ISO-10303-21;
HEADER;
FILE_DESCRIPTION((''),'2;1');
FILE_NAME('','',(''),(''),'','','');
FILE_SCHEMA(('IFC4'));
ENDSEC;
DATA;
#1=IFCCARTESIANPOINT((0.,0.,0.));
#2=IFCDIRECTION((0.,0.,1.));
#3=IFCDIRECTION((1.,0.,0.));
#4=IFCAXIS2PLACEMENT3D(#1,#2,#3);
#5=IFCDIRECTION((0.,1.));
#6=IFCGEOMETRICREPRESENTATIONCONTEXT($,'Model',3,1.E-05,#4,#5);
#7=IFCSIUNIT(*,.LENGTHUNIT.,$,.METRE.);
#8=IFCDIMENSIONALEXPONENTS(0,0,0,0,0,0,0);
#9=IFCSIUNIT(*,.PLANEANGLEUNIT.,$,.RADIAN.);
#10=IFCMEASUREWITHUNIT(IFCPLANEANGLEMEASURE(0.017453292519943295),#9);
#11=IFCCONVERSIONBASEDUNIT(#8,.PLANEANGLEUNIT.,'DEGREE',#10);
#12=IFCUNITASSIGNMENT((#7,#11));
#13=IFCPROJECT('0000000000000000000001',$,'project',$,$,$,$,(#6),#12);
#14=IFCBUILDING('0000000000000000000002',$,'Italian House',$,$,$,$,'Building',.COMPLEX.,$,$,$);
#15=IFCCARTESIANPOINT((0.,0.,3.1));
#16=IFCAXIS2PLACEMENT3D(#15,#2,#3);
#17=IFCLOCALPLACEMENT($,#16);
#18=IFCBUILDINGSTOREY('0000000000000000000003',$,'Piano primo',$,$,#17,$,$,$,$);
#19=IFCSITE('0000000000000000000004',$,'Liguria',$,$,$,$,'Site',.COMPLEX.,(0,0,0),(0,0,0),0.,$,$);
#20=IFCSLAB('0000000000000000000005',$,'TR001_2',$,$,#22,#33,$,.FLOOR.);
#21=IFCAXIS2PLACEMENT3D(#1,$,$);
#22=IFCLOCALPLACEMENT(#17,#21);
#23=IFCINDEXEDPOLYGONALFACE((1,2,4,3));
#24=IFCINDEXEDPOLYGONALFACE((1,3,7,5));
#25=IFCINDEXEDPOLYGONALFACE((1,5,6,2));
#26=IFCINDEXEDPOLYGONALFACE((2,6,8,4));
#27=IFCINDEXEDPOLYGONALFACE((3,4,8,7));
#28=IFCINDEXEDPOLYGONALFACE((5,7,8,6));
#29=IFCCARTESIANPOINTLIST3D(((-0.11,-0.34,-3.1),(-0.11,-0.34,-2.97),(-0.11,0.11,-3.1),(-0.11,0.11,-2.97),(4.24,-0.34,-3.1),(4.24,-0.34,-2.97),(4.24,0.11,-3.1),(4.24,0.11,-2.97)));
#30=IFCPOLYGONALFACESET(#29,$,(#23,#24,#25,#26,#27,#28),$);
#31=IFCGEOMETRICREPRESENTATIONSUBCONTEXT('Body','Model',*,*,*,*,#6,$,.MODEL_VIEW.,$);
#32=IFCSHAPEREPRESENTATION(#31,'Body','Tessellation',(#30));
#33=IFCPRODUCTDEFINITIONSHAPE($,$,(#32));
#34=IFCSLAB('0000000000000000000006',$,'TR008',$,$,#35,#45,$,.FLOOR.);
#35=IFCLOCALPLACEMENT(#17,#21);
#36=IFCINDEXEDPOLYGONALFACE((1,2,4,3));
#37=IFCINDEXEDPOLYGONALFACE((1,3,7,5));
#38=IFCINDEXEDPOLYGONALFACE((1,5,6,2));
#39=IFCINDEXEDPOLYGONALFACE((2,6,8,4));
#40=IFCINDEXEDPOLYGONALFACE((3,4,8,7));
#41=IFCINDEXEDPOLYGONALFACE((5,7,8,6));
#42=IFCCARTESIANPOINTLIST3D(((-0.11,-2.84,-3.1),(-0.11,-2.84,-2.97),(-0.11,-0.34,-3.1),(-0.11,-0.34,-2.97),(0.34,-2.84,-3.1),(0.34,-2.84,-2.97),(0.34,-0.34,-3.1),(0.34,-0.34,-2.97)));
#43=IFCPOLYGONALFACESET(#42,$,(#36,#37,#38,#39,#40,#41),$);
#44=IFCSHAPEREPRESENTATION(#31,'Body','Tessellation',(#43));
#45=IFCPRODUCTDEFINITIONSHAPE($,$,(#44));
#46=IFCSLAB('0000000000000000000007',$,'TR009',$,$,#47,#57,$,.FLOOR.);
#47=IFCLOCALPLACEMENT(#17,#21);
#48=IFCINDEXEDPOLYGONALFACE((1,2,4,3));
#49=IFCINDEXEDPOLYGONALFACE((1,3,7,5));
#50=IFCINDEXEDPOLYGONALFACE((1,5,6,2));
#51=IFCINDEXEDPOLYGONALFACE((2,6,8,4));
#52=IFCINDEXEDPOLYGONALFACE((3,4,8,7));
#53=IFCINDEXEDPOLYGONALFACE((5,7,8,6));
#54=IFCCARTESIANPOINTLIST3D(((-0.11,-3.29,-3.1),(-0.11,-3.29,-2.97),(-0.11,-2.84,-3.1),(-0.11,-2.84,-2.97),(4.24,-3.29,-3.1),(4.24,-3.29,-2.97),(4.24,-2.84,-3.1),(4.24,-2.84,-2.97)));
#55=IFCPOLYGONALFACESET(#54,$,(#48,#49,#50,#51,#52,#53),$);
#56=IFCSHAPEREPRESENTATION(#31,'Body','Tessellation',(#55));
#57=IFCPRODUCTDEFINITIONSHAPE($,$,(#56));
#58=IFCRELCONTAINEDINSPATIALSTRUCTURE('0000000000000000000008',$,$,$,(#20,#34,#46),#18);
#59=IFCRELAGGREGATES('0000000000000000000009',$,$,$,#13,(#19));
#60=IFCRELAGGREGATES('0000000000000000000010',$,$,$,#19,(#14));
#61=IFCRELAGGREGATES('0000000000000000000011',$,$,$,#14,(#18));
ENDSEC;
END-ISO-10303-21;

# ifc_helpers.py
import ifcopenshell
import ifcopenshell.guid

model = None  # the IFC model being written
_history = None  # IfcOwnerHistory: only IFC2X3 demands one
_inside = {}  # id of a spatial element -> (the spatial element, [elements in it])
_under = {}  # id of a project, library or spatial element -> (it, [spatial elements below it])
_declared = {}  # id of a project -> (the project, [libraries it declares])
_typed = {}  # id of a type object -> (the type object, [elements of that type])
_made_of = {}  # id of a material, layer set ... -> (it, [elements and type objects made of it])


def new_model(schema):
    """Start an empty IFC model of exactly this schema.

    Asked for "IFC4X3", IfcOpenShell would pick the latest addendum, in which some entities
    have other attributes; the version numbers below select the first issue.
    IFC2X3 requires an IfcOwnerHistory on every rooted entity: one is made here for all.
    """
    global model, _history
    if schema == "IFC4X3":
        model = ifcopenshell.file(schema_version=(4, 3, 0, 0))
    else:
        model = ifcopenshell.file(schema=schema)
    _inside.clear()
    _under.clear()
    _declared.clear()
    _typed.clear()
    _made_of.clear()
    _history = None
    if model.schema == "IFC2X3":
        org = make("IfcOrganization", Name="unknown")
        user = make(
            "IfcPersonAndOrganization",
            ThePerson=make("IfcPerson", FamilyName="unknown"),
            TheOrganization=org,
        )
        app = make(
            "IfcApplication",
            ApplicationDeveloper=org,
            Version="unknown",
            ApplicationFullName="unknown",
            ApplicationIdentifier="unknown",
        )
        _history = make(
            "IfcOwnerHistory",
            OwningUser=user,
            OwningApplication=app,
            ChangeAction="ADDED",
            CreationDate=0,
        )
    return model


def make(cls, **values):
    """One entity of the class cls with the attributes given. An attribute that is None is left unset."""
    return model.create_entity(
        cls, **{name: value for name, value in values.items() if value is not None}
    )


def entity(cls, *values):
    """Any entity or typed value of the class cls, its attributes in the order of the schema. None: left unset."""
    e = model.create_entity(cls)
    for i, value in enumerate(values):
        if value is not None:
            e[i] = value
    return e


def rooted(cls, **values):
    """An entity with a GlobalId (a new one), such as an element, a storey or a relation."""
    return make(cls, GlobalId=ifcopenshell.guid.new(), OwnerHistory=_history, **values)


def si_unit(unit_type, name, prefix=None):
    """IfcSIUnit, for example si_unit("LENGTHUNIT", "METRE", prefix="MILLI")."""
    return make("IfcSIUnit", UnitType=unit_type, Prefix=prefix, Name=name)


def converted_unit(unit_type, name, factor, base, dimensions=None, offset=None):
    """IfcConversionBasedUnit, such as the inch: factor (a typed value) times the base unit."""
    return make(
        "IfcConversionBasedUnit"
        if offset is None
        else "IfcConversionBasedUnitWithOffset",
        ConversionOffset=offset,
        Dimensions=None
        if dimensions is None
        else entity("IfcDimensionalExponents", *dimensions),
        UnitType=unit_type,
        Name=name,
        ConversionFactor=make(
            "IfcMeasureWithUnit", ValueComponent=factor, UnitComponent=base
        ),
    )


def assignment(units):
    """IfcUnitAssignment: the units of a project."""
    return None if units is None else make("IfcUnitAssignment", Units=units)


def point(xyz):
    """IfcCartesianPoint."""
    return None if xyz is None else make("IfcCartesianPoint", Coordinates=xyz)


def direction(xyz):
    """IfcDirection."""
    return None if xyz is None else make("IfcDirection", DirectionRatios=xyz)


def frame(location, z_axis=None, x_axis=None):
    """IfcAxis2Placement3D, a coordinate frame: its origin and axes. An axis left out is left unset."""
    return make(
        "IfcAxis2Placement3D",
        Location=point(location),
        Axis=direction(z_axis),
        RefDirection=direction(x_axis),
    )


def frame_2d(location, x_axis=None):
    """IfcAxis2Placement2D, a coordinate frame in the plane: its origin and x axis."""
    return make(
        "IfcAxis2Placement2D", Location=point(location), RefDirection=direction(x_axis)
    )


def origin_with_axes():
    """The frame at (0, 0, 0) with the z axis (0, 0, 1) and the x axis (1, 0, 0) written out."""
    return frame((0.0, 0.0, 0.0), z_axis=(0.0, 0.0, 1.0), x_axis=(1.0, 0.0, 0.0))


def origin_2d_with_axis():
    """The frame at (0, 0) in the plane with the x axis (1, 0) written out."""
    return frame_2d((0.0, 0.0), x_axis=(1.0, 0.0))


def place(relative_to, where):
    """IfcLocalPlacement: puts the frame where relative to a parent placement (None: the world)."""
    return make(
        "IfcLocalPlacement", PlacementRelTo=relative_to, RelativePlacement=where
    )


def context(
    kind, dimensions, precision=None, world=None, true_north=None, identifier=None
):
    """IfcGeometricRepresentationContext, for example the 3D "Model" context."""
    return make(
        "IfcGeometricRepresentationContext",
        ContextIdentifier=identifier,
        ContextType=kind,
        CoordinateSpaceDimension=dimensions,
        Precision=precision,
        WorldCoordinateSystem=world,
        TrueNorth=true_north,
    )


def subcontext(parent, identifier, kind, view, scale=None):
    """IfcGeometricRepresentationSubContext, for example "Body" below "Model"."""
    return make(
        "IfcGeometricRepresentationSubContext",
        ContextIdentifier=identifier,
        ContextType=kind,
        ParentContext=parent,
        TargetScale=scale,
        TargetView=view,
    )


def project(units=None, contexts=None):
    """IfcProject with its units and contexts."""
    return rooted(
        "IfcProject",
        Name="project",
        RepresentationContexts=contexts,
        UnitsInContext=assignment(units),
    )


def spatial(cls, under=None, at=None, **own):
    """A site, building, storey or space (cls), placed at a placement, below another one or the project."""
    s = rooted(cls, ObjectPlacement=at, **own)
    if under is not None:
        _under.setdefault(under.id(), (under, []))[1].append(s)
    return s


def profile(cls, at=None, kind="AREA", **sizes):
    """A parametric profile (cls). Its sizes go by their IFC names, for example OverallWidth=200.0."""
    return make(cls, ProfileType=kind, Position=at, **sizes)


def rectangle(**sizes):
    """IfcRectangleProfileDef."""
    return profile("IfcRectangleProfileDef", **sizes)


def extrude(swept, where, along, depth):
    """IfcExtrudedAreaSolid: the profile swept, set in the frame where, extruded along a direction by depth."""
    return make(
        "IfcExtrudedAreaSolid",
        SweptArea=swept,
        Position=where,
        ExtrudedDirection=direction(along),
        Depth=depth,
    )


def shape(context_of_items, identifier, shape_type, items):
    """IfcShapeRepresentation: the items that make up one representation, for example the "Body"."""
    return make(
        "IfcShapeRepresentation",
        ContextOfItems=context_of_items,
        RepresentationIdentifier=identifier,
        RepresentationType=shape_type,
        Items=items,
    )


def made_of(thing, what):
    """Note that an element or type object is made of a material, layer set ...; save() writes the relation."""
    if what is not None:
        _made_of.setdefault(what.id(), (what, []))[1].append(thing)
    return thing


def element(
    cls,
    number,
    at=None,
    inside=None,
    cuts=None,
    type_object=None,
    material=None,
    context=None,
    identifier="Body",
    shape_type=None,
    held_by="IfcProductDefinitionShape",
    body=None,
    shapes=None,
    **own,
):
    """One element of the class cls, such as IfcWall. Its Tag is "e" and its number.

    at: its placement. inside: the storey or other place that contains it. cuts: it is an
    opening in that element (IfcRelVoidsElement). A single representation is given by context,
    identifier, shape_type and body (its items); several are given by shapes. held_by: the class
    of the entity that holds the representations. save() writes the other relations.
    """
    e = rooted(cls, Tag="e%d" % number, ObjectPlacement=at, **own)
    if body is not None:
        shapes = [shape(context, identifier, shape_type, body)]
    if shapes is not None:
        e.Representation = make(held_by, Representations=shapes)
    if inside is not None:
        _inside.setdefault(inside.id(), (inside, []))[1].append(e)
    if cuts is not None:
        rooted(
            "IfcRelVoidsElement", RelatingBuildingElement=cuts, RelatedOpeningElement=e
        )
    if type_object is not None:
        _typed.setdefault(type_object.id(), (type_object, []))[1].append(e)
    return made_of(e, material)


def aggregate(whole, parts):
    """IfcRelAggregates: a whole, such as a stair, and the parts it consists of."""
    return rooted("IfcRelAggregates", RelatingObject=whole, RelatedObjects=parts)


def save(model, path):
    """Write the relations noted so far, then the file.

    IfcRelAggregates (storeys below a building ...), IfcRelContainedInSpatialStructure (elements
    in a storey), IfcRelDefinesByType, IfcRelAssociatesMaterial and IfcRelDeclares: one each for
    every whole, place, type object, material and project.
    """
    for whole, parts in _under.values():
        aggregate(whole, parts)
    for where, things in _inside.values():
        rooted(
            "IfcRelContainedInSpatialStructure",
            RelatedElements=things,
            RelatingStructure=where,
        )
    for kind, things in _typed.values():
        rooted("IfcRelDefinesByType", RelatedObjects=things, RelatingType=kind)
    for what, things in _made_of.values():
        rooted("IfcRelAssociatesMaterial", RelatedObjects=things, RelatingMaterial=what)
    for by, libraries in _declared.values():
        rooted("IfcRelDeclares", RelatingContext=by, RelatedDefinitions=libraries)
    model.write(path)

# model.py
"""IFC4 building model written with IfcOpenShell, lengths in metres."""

from ifc_helpers import new_model, entity, si_unit, converted_unit, direction, frame, frame_2d, origin_with_axes, origin_2d_with_axis, place, context, subcontext, project, spatial, rectangle, extrude, element, save


model = new_model("IFC4")

# Units and contexts
model_context = context("Model", 3, precision=1e-05, world=origin_with_axes(), true_north=direction((0.0, 1.0)))
body_context = subcontext(model_context, "Body", "Model", "MODEL_VIEW")
ifc_project = project(units=[si_unit("LENGTHUNIT", "METRE"), converted_unit("PLANEANGLEUNIT", "DEGREE", entity("IfcPlaneAngleMeasure", 0.017453292519943295), si_unit("PLANEANGLEUNIT", "RADIAN"), dimensions=[0, 0, 0, 0, 0, 0, 0])], contexts=[model_context])

# Site, building, storey
site = spatial("IfcSite", under=ifc_project, Name="Liguria", LongName="Site", CompositionType="COMPLEX", RefLatitude=(0, 0, 0), RefLongitude=(0, 0, 0), RefElevation=0.0)
building = spatial("IfcBuilding", under=site, Name="Italian House", LongName="Building", CompositionType="COMPLEX")
storey_placement = place(None, frame((0.0, 0.0, 3.1), z_axis=(0.0, 0.0, 1.0), x_axis=(1.0, 0.0, 0.0)))
storey = spatial("IfcBuildingStorey", under=building, at=storey_placement, Name="Piano primo")

# Slabs
slab_1_placement = place(storey_placement, frame((0.0, 0.0, -3.1), z_axis=(0.0, 0.0, 1.0), x_axis=(1.0, 0.0, 0.0)))
element("IfcSlab", 1, at=slab_1_placement, inside=storey, Name="TR001_2", PredefinedType="FLOOR", context=body_context, shape_type="SweptSolid", body=[
    extrude(rectangle(XDim=4.35, YDim=0.45, at=frame_2d((0.0, 0.0), x_axis=(1.0, 0.0))), frame((2.065, -0.115, 0.13), z_axis=(0.0, 0.0, 1.0), x_axis=(1.0, 0.0, 0.0)), (0.0, 0.0, -1.0), 0.13),
])
slab_2_placement = place(storey_placement, frame((0.0, 0.0, -3.1), z_axis=(0.0, 0.0, 1.0), x_axis=(1.0, 0.0, 0.0)))
element("IfcSlab", 2, at=slab_2_placement, inside=storey, Name="TR008", PredefinedType="FLOOR", context=body_context, shape_type="SweptSolid", body=[
    extrude(rectangle(XDim=0.45, YDim=2.5, at=origin_2d_with_axis()), frame((0.115, -1.59, 0.13), z_axis=(0.0, 0.0, 1.0), x_axis=(1.0, 0.0, 0.0)), (0.0, 0.0, -1.0), 0.13),
])
slab_3_placement = place(storey_placement, frame((0.0, 0.0, -3.1), z_axis=(0.0, 0.0, 1.0), x_axis=(1.0, 0.0, 0.0)))
element("IfcSlab", 3, at=slab_3_placement, inside=storey, Name="TR009", PredefinedType="FLOOR", context=body_context, shape_type="SweptSolid", body=[
    extrude(rectangle(XDim=4.35, YDim=0.45, at=frame_2d((0.0, 0.0), x_axis=(1.0, 0.0))), frame((2.065, -3.065, 0.13), z_axis=(0.0, 0.0, 1.0), x_axis=(1.0, 0.0, 0.0)), (0.0, 0.0, -1.0), 0.13),
])

save(model, "model.ifc")
